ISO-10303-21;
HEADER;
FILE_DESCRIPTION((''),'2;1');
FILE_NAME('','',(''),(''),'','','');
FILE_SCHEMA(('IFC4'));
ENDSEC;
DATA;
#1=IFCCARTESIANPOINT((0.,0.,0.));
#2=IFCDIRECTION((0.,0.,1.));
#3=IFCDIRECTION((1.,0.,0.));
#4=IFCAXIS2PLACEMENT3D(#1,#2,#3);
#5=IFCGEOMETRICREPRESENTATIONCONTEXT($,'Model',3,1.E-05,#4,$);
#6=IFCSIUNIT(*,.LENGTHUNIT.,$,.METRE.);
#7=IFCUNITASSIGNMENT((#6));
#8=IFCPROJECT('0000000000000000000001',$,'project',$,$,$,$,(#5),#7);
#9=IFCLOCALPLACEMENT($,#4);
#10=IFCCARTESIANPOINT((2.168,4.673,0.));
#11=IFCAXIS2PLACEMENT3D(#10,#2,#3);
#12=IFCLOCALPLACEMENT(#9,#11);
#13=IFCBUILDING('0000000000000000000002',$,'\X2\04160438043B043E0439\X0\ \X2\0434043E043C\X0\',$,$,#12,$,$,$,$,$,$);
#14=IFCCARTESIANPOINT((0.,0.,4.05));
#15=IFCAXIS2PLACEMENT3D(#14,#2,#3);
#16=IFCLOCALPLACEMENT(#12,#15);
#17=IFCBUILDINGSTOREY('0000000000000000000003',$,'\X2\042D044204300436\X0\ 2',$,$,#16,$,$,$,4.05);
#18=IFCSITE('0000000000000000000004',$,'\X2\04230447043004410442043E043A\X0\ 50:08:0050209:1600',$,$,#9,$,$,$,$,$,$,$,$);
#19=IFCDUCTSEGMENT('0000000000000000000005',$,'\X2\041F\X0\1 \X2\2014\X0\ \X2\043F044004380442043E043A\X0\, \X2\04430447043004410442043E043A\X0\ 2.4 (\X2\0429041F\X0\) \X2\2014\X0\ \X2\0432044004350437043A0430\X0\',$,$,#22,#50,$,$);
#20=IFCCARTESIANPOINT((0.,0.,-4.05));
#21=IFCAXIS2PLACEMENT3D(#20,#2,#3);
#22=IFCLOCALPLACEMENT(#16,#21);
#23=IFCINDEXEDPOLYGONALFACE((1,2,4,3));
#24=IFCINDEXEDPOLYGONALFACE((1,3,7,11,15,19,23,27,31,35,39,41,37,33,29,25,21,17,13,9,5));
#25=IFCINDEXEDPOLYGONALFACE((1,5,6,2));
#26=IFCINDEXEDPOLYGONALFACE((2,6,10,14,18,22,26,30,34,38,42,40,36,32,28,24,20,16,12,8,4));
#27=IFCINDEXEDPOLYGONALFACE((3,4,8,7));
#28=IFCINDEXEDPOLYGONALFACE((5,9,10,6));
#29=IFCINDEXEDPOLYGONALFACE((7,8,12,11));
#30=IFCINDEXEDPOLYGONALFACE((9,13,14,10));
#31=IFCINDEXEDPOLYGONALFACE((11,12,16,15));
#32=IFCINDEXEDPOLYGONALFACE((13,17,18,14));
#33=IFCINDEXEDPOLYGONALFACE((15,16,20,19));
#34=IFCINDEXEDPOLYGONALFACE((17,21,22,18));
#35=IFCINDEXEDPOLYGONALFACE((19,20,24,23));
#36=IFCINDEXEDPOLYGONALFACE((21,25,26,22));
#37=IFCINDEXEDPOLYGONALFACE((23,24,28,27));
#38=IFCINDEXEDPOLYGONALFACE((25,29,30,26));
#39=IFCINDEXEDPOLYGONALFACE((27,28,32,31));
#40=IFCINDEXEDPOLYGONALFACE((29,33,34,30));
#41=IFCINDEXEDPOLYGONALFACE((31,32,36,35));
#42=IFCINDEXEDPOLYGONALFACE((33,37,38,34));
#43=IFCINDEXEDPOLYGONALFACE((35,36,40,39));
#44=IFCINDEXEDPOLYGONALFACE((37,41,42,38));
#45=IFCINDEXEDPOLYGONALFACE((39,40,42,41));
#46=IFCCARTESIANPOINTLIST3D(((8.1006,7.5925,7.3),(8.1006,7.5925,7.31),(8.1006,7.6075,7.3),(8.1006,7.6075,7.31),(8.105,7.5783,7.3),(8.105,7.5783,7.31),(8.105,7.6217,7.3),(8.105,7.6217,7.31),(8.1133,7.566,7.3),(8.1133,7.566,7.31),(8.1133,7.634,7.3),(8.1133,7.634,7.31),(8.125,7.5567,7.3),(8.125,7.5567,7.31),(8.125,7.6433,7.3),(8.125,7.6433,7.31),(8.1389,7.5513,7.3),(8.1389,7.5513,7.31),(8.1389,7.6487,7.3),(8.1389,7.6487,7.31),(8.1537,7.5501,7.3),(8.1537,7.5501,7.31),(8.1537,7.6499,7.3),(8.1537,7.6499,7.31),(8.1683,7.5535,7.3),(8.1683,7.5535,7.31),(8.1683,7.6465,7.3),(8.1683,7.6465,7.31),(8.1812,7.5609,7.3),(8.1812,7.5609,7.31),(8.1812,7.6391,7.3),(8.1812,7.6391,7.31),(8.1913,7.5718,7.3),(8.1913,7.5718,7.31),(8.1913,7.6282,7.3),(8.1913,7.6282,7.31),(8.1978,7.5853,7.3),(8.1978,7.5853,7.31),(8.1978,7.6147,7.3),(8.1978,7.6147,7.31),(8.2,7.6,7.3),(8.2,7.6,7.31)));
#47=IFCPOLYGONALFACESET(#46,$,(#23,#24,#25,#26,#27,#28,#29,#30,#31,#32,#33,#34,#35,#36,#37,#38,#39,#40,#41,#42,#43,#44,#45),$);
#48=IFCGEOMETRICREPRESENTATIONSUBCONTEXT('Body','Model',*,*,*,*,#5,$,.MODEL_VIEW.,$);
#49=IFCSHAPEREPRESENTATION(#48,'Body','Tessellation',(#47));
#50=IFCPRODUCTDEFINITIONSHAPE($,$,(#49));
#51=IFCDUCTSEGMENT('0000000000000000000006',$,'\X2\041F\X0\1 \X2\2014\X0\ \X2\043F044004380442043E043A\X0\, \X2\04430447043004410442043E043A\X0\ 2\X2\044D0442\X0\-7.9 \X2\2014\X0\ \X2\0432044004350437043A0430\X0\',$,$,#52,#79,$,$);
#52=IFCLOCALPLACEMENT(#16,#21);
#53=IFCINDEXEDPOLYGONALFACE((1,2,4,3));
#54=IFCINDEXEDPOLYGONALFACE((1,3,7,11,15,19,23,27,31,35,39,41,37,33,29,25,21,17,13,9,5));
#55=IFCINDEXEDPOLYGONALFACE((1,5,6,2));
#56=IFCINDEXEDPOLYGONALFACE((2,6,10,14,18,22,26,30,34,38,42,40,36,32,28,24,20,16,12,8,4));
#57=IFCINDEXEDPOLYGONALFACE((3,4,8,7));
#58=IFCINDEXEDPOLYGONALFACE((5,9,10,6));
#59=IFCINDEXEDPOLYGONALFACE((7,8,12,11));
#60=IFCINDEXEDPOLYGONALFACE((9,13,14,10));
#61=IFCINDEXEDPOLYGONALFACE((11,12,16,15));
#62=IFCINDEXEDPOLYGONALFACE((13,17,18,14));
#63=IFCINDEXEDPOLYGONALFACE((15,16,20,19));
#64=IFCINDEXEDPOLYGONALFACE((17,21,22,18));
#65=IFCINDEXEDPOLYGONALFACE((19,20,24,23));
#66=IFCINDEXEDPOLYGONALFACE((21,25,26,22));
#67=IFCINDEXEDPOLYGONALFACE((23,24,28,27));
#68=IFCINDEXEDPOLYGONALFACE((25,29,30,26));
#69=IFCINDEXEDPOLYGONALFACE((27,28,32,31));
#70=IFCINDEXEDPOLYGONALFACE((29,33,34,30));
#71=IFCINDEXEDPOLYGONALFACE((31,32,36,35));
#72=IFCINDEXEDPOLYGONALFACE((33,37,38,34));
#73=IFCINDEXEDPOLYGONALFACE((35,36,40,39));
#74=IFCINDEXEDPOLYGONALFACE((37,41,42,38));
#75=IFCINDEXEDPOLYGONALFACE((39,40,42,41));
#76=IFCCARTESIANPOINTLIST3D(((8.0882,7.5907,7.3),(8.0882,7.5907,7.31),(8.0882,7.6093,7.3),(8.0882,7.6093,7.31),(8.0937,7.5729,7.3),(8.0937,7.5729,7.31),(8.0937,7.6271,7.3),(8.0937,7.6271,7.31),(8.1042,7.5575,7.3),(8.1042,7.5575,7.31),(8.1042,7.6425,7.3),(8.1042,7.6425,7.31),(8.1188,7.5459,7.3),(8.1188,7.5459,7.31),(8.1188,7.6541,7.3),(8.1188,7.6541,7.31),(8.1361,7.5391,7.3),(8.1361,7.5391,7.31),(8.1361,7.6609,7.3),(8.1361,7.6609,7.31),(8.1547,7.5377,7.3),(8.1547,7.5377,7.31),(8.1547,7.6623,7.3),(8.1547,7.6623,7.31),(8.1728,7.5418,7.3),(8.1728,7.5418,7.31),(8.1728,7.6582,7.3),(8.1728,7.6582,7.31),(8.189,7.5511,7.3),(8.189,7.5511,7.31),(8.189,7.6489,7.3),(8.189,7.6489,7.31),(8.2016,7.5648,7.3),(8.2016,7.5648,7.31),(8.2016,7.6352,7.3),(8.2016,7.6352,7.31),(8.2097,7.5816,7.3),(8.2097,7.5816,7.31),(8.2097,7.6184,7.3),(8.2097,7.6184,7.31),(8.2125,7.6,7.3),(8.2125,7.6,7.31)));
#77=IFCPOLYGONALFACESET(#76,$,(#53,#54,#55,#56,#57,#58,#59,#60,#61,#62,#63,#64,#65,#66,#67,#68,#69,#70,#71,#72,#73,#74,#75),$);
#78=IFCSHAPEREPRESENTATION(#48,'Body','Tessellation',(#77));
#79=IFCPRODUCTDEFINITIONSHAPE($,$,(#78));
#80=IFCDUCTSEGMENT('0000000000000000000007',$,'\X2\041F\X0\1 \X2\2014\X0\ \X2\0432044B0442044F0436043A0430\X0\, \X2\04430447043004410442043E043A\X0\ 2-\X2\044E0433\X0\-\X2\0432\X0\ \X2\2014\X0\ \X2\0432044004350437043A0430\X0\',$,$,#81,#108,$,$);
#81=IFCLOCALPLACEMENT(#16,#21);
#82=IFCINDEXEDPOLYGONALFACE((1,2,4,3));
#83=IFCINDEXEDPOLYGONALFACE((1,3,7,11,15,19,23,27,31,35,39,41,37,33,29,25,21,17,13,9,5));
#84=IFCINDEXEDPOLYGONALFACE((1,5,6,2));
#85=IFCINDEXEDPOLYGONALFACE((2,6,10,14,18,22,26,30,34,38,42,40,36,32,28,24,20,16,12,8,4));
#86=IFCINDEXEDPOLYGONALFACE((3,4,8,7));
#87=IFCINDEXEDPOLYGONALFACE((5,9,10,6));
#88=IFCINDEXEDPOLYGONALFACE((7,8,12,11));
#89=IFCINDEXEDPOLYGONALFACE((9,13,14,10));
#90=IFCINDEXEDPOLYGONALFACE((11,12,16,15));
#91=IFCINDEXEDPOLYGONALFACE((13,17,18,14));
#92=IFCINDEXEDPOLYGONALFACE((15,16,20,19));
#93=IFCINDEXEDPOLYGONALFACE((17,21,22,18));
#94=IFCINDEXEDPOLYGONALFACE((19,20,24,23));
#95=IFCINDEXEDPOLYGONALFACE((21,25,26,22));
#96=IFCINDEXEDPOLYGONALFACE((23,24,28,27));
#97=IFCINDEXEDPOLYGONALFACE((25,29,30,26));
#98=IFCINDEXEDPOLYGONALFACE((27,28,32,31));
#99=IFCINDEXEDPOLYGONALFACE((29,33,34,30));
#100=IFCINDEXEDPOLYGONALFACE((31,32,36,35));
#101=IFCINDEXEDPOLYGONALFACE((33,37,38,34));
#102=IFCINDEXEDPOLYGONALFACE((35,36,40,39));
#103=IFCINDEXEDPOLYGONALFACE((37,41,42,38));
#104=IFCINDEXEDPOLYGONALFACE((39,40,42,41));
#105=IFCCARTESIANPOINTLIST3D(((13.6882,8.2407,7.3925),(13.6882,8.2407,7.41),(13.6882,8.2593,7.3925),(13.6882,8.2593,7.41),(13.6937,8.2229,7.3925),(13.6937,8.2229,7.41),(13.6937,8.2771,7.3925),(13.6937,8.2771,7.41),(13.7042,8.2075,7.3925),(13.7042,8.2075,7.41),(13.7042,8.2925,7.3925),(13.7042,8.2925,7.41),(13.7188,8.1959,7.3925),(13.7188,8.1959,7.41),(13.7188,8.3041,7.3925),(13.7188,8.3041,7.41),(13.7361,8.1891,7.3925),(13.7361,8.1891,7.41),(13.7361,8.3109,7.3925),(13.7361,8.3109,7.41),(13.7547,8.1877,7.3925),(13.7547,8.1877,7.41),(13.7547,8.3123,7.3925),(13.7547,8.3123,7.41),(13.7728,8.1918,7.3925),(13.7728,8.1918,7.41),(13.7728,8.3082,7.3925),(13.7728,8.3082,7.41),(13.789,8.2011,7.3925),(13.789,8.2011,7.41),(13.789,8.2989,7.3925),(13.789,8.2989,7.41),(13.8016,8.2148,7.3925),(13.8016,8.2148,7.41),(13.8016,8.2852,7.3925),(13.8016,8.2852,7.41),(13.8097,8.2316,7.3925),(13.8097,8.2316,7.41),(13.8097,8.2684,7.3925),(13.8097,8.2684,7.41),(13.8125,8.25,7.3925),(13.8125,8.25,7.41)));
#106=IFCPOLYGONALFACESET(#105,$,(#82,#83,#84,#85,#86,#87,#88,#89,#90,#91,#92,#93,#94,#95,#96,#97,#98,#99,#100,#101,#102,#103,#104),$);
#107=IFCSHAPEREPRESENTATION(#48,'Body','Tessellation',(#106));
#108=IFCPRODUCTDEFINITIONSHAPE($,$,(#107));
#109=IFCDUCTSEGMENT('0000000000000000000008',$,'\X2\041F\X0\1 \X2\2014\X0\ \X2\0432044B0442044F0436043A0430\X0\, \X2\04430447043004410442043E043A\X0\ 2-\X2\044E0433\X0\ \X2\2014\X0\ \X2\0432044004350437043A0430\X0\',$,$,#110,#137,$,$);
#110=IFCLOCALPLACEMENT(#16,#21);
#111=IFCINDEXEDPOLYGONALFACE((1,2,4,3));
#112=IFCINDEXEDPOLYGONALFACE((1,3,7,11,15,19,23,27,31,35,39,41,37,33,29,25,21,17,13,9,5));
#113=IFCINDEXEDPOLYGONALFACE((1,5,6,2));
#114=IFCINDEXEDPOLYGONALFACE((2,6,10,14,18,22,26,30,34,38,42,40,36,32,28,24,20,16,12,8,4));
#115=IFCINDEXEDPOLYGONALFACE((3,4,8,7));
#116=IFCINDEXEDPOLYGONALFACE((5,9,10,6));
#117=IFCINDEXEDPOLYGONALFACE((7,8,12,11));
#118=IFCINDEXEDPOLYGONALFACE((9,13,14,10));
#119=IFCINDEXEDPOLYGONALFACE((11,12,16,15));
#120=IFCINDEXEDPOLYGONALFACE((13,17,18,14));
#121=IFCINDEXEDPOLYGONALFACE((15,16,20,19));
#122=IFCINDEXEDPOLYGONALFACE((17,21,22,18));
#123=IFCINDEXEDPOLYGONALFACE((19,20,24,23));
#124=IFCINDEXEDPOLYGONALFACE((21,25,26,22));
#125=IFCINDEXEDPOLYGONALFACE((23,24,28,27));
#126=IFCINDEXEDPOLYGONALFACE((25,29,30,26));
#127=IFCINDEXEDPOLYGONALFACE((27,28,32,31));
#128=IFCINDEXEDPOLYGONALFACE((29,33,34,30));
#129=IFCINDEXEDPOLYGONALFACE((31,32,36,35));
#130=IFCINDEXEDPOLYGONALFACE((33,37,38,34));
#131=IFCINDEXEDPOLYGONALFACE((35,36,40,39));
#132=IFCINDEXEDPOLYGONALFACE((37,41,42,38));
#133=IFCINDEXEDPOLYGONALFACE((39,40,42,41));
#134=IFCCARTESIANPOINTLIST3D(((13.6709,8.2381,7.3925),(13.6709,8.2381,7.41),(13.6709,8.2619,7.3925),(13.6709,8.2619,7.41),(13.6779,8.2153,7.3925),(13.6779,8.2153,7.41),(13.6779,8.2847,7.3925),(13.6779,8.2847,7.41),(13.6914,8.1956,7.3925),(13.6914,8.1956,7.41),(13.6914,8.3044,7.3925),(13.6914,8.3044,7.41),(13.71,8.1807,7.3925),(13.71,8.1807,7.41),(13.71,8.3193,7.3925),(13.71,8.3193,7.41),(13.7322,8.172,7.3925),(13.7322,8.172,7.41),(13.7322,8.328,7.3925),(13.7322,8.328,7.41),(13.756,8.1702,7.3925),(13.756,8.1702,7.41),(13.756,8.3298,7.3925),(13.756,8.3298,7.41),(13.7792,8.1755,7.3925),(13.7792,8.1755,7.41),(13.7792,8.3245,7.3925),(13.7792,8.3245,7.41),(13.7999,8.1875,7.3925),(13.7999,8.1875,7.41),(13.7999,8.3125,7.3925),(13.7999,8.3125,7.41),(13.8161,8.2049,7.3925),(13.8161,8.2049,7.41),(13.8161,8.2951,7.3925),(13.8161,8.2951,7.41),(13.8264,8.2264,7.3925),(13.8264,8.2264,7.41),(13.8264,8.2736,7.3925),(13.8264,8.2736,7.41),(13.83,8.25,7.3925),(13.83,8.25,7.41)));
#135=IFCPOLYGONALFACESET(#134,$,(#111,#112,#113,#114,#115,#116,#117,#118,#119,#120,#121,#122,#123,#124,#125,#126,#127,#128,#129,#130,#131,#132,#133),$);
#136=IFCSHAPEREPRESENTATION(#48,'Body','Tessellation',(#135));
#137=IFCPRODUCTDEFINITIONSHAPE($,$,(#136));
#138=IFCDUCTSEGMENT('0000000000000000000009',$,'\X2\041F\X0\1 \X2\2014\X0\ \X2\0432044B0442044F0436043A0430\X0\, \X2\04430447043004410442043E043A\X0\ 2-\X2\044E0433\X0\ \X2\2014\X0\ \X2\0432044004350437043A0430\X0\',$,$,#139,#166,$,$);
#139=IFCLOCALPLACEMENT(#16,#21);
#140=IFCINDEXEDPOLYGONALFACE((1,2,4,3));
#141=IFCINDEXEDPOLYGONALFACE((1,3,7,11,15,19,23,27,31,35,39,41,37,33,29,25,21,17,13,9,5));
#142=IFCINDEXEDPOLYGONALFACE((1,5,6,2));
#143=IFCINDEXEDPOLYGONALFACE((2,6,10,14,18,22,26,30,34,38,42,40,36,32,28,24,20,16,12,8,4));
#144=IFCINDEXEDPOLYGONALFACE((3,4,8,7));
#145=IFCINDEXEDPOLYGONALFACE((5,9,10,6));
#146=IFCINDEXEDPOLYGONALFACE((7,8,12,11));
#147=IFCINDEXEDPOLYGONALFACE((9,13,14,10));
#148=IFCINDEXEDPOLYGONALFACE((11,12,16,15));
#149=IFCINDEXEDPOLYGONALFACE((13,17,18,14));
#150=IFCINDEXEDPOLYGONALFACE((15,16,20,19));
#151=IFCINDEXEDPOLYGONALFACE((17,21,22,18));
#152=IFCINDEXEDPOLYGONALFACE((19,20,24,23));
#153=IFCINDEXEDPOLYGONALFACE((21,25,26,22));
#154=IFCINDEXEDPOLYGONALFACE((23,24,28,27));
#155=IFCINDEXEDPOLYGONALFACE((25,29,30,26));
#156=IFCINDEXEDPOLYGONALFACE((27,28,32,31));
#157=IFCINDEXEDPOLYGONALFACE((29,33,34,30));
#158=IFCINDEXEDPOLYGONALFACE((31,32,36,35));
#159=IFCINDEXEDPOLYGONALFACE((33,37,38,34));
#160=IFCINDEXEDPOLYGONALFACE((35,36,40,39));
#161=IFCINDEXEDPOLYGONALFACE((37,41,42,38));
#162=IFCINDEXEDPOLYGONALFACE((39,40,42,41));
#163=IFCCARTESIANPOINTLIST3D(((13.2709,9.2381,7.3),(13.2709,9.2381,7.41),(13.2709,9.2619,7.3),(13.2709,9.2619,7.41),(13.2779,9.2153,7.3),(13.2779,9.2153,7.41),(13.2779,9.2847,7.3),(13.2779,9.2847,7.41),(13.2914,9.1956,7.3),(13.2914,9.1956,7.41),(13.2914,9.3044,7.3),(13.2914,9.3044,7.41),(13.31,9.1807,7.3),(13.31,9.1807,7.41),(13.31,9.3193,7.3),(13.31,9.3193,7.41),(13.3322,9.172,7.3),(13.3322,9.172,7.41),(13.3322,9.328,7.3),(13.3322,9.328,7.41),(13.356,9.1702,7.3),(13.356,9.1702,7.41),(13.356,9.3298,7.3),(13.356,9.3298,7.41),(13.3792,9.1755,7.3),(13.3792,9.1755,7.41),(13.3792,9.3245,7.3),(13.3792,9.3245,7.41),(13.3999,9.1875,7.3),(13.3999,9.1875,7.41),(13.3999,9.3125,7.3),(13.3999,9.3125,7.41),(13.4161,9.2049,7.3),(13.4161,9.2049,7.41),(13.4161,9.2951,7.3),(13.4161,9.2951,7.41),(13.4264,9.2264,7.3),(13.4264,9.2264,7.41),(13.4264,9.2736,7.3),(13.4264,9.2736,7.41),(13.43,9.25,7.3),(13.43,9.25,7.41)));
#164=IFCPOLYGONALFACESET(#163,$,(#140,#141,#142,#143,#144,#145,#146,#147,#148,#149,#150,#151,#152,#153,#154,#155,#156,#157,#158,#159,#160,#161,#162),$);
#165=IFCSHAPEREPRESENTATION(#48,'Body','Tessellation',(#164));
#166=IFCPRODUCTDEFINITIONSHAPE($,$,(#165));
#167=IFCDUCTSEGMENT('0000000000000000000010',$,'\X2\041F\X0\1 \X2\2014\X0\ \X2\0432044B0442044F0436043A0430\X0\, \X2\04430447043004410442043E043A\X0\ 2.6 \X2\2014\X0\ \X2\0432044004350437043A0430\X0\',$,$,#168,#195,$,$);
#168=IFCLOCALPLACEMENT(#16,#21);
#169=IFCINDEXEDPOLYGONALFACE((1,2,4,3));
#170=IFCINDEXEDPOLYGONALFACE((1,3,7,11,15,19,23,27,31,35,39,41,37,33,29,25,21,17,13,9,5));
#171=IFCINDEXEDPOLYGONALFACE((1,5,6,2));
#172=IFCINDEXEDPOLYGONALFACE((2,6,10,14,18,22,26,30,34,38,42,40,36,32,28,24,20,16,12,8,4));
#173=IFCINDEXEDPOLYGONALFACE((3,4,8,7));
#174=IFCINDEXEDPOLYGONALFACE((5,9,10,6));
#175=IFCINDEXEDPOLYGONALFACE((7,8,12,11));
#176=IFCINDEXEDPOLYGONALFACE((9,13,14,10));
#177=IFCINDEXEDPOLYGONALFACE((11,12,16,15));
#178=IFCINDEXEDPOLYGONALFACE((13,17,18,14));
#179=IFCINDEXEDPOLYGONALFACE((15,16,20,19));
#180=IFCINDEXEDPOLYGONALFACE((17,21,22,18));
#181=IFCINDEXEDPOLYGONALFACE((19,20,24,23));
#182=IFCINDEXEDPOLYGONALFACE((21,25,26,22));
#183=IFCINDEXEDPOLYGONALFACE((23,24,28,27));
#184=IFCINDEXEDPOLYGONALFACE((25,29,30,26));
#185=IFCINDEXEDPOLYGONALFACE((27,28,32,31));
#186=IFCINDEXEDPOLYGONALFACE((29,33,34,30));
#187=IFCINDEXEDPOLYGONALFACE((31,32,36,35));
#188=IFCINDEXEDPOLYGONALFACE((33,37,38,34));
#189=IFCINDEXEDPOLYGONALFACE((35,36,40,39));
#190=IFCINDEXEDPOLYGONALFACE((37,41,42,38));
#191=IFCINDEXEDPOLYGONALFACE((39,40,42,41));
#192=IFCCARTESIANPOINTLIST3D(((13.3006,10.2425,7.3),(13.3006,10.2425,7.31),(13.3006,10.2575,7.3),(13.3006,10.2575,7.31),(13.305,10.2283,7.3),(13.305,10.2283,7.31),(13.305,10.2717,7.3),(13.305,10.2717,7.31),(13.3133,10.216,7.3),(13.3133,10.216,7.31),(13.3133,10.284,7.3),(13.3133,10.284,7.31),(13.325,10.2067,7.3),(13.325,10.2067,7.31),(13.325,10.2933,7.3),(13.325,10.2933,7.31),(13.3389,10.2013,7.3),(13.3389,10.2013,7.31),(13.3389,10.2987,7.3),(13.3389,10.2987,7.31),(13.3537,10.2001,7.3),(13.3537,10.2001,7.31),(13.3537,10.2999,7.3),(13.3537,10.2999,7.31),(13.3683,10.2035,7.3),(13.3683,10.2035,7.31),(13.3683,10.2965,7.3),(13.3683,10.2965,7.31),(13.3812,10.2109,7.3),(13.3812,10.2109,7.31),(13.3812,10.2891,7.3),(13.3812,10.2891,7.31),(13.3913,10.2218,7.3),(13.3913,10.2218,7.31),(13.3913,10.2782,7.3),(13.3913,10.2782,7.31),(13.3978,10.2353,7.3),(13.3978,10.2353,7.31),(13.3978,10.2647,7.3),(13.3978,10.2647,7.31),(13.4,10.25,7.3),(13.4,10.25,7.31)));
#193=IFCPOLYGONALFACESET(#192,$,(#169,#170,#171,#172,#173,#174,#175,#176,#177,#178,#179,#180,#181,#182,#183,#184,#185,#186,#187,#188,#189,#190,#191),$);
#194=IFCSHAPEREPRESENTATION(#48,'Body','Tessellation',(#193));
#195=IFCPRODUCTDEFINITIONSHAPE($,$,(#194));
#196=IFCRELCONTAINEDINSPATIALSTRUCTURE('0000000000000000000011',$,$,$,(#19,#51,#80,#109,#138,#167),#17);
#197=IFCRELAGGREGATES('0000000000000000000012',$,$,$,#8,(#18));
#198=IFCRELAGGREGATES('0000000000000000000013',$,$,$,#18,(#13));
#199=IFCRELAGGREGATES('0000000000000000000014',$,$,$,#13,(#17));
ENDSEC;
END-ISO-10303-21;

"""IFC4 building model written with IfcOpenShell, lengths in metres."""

from ifc_helpers import new_model, si_unit, frame, origin_with_axes, origin_2d, place, context, subcontext, project, spatial, circle, extrude, element, save


model = new_model("IFC4")

# Units and contexts
model_context = context("Model", 3, precision=1e-05, world=origin_with_axes())
body_context = subcontext(model_context, "Body", "Model", "MODEL_VIEW")
ifc_project = project(units=[si_unit("LENGTHUNIT", "METRE")], contexts=[model_context])

# Site, building, storey
site_placement = place(None, origin_with_axes())
site = spatial("IfcSite", under=ifc_project, at=site_placement, Name="Участок 50:08:0050209:1600")
building_placement = place(site_placement, frame((2.168, 4.673, 0.0), z_axis=(0.0, 0.0, 1.0), x_axis=(1.0, 0.0, 0.0)))
building = spatial("IfcBuilding", under=site, at=building_placement, Name="Жилой дом")
storey_placement = place(building_placement, frame((0.0, 0.0, 4.05), z_axis=(0.0, 0.0, 1.0), x_axis=(1.0, 0.0, 0.0)))
storey = spatial("IfcBuildingStorey", under=building, at=storey_placement, Name="Этаж 2", Elevation=4.05)

# Duct segments
duct_segment_1_placement = place(storey_placement, frame((0.0, 0.0, -4.05), z_axis=(0.0, 0.0, 1.0), x_axis=(1.0, 0.0, 0.0)))
element("IfcDuctSegment", 1, at=duct_segment_1_placement, inside=storey, Name="П1 — приток, участок 2.4 (ЩП) — врезка", context=body_context, shape_type="SweptSolid", body=[
    extrude(circle(Radius=0.05, at=origin_2d()), frame((8.15, 7.6, 7.3), z_axis=(0.0, 0.0, 1.0), x_axis=(1.0, 0.0, 0.0)), (0.0, 0.0, 1.0), 0.01),
])
duct_segment_2_placement = place(storey_placement, frame((0.0, 0.0, -4.05), z_axis=(0.0, 0.0, 1.0), x_axis=(1.0, 0.0, 0.0)))
element("IfcDuctSegment", 2, at=duct_segment_2_placement, inside=storey, Name="П1 — приток, участок 2эт-7.9 — врезка", context=body_context, shape_type="SweptSolid", body=[
    extrude(circle(Radius=0.0625, at=origin_2d()), frame((8.15, 7.6, 7.3), z_axis=(0.0, 0.0, 1.0), x_axis=(1.0, 0.0, 0.0)), (0.0, 0.0, 1.0), 0.01),
])
duct_segment_3_placement = place(storey_placement, frame((0.0, 0.0, -4.05), z_axis=(0.0, 0.0, 1.0), x_axis=(1.0, 0.0, 0.0)))
element("IfcDuctSegment", 3, at=duct_segment_3_placement, inside=storey, Name="П1 — вытяжка, участок 2-юг-в — врезка", context=body_context, shape_type="SweptSolid", body=[
    extrude(circle(Radius=0.0625, at=origin_2d()), frame((13.75, 8.25, 7.3925), z_axis=(0.0, 0.0, 1.0), x_axis=(1.0, 0.0, 0.0)), (0.0, 0.0, 1.0), 0.0175),
])
duct_segment_4_placement = place(storey_placement, frame((0.0, 0.0, -4.05), z_axis=(0.0, 0.0, 1.0), x_axis=(1.0, 0.0, 0.0)))
element("IfcDuctSegment", 4, at=duct_segment_4_placement, inside=storey, Name="П1 — вытяжка, участок 2-юг — врезка", context=body_context, shape_type="SweptSolid", body=[
    extrude(circle(Radius=0.08, at=origin_2d()), frame((13.75, 8.25, 7.41), z_axis=(0.0, 0.0, -1.0), x_axis=(1.0, 0.0, 0.0)), (0.0, 0.0, 1.0), 0.0175),
])
duct_segment_5_placement = place(storey_placement, frame((0.0, 0.0, -4.05), z_axis=(0.0, 0.0, 1.0), x_axis=(1.0, 0.0, 0.0)))
element("IfcDuctSegment", 5, at=duct_segment_5_placement, inside=storey, Name="П1 — вытяжка, участок 2-юг — врезка", context=body_context, shape_type="SweptSolid", body=[
    extrude(circle(Radius=0.08, at=origin_2d()), frame((13.35, 9.25, 7.41), z_axis=(0.0, 0.0, -1.0), x_axis=(1.0, 0.0, 0.0)), (0.0, 0.0, 1.0), 0.11),
])
duct_segment_6_placement = place(storey_placement, frame((0.0, 0.0, -4.05), z_axis=(0.0, 0.0, 1.0), x_axis=(1.0, 0.0, 0.0)))
element("IfcDuctSegment", 6, at=duct_segment_6_placement, inside=storey, Name="П1 — вытяжка, участок 2.6 — врезка", context=body_context, shape_type="SweptSolid", body=[
    extrude(circle(Radius=0.05, at=origin_2d()), frame((13.35, 10.25, 7.3), z_axis=(0.0, 0.0, 1.0), x_axis=(1.0, 0.0, 0.0)), (0.0, 0.0, 1.0), 0.01),
])

save(model, "model.ifc")
